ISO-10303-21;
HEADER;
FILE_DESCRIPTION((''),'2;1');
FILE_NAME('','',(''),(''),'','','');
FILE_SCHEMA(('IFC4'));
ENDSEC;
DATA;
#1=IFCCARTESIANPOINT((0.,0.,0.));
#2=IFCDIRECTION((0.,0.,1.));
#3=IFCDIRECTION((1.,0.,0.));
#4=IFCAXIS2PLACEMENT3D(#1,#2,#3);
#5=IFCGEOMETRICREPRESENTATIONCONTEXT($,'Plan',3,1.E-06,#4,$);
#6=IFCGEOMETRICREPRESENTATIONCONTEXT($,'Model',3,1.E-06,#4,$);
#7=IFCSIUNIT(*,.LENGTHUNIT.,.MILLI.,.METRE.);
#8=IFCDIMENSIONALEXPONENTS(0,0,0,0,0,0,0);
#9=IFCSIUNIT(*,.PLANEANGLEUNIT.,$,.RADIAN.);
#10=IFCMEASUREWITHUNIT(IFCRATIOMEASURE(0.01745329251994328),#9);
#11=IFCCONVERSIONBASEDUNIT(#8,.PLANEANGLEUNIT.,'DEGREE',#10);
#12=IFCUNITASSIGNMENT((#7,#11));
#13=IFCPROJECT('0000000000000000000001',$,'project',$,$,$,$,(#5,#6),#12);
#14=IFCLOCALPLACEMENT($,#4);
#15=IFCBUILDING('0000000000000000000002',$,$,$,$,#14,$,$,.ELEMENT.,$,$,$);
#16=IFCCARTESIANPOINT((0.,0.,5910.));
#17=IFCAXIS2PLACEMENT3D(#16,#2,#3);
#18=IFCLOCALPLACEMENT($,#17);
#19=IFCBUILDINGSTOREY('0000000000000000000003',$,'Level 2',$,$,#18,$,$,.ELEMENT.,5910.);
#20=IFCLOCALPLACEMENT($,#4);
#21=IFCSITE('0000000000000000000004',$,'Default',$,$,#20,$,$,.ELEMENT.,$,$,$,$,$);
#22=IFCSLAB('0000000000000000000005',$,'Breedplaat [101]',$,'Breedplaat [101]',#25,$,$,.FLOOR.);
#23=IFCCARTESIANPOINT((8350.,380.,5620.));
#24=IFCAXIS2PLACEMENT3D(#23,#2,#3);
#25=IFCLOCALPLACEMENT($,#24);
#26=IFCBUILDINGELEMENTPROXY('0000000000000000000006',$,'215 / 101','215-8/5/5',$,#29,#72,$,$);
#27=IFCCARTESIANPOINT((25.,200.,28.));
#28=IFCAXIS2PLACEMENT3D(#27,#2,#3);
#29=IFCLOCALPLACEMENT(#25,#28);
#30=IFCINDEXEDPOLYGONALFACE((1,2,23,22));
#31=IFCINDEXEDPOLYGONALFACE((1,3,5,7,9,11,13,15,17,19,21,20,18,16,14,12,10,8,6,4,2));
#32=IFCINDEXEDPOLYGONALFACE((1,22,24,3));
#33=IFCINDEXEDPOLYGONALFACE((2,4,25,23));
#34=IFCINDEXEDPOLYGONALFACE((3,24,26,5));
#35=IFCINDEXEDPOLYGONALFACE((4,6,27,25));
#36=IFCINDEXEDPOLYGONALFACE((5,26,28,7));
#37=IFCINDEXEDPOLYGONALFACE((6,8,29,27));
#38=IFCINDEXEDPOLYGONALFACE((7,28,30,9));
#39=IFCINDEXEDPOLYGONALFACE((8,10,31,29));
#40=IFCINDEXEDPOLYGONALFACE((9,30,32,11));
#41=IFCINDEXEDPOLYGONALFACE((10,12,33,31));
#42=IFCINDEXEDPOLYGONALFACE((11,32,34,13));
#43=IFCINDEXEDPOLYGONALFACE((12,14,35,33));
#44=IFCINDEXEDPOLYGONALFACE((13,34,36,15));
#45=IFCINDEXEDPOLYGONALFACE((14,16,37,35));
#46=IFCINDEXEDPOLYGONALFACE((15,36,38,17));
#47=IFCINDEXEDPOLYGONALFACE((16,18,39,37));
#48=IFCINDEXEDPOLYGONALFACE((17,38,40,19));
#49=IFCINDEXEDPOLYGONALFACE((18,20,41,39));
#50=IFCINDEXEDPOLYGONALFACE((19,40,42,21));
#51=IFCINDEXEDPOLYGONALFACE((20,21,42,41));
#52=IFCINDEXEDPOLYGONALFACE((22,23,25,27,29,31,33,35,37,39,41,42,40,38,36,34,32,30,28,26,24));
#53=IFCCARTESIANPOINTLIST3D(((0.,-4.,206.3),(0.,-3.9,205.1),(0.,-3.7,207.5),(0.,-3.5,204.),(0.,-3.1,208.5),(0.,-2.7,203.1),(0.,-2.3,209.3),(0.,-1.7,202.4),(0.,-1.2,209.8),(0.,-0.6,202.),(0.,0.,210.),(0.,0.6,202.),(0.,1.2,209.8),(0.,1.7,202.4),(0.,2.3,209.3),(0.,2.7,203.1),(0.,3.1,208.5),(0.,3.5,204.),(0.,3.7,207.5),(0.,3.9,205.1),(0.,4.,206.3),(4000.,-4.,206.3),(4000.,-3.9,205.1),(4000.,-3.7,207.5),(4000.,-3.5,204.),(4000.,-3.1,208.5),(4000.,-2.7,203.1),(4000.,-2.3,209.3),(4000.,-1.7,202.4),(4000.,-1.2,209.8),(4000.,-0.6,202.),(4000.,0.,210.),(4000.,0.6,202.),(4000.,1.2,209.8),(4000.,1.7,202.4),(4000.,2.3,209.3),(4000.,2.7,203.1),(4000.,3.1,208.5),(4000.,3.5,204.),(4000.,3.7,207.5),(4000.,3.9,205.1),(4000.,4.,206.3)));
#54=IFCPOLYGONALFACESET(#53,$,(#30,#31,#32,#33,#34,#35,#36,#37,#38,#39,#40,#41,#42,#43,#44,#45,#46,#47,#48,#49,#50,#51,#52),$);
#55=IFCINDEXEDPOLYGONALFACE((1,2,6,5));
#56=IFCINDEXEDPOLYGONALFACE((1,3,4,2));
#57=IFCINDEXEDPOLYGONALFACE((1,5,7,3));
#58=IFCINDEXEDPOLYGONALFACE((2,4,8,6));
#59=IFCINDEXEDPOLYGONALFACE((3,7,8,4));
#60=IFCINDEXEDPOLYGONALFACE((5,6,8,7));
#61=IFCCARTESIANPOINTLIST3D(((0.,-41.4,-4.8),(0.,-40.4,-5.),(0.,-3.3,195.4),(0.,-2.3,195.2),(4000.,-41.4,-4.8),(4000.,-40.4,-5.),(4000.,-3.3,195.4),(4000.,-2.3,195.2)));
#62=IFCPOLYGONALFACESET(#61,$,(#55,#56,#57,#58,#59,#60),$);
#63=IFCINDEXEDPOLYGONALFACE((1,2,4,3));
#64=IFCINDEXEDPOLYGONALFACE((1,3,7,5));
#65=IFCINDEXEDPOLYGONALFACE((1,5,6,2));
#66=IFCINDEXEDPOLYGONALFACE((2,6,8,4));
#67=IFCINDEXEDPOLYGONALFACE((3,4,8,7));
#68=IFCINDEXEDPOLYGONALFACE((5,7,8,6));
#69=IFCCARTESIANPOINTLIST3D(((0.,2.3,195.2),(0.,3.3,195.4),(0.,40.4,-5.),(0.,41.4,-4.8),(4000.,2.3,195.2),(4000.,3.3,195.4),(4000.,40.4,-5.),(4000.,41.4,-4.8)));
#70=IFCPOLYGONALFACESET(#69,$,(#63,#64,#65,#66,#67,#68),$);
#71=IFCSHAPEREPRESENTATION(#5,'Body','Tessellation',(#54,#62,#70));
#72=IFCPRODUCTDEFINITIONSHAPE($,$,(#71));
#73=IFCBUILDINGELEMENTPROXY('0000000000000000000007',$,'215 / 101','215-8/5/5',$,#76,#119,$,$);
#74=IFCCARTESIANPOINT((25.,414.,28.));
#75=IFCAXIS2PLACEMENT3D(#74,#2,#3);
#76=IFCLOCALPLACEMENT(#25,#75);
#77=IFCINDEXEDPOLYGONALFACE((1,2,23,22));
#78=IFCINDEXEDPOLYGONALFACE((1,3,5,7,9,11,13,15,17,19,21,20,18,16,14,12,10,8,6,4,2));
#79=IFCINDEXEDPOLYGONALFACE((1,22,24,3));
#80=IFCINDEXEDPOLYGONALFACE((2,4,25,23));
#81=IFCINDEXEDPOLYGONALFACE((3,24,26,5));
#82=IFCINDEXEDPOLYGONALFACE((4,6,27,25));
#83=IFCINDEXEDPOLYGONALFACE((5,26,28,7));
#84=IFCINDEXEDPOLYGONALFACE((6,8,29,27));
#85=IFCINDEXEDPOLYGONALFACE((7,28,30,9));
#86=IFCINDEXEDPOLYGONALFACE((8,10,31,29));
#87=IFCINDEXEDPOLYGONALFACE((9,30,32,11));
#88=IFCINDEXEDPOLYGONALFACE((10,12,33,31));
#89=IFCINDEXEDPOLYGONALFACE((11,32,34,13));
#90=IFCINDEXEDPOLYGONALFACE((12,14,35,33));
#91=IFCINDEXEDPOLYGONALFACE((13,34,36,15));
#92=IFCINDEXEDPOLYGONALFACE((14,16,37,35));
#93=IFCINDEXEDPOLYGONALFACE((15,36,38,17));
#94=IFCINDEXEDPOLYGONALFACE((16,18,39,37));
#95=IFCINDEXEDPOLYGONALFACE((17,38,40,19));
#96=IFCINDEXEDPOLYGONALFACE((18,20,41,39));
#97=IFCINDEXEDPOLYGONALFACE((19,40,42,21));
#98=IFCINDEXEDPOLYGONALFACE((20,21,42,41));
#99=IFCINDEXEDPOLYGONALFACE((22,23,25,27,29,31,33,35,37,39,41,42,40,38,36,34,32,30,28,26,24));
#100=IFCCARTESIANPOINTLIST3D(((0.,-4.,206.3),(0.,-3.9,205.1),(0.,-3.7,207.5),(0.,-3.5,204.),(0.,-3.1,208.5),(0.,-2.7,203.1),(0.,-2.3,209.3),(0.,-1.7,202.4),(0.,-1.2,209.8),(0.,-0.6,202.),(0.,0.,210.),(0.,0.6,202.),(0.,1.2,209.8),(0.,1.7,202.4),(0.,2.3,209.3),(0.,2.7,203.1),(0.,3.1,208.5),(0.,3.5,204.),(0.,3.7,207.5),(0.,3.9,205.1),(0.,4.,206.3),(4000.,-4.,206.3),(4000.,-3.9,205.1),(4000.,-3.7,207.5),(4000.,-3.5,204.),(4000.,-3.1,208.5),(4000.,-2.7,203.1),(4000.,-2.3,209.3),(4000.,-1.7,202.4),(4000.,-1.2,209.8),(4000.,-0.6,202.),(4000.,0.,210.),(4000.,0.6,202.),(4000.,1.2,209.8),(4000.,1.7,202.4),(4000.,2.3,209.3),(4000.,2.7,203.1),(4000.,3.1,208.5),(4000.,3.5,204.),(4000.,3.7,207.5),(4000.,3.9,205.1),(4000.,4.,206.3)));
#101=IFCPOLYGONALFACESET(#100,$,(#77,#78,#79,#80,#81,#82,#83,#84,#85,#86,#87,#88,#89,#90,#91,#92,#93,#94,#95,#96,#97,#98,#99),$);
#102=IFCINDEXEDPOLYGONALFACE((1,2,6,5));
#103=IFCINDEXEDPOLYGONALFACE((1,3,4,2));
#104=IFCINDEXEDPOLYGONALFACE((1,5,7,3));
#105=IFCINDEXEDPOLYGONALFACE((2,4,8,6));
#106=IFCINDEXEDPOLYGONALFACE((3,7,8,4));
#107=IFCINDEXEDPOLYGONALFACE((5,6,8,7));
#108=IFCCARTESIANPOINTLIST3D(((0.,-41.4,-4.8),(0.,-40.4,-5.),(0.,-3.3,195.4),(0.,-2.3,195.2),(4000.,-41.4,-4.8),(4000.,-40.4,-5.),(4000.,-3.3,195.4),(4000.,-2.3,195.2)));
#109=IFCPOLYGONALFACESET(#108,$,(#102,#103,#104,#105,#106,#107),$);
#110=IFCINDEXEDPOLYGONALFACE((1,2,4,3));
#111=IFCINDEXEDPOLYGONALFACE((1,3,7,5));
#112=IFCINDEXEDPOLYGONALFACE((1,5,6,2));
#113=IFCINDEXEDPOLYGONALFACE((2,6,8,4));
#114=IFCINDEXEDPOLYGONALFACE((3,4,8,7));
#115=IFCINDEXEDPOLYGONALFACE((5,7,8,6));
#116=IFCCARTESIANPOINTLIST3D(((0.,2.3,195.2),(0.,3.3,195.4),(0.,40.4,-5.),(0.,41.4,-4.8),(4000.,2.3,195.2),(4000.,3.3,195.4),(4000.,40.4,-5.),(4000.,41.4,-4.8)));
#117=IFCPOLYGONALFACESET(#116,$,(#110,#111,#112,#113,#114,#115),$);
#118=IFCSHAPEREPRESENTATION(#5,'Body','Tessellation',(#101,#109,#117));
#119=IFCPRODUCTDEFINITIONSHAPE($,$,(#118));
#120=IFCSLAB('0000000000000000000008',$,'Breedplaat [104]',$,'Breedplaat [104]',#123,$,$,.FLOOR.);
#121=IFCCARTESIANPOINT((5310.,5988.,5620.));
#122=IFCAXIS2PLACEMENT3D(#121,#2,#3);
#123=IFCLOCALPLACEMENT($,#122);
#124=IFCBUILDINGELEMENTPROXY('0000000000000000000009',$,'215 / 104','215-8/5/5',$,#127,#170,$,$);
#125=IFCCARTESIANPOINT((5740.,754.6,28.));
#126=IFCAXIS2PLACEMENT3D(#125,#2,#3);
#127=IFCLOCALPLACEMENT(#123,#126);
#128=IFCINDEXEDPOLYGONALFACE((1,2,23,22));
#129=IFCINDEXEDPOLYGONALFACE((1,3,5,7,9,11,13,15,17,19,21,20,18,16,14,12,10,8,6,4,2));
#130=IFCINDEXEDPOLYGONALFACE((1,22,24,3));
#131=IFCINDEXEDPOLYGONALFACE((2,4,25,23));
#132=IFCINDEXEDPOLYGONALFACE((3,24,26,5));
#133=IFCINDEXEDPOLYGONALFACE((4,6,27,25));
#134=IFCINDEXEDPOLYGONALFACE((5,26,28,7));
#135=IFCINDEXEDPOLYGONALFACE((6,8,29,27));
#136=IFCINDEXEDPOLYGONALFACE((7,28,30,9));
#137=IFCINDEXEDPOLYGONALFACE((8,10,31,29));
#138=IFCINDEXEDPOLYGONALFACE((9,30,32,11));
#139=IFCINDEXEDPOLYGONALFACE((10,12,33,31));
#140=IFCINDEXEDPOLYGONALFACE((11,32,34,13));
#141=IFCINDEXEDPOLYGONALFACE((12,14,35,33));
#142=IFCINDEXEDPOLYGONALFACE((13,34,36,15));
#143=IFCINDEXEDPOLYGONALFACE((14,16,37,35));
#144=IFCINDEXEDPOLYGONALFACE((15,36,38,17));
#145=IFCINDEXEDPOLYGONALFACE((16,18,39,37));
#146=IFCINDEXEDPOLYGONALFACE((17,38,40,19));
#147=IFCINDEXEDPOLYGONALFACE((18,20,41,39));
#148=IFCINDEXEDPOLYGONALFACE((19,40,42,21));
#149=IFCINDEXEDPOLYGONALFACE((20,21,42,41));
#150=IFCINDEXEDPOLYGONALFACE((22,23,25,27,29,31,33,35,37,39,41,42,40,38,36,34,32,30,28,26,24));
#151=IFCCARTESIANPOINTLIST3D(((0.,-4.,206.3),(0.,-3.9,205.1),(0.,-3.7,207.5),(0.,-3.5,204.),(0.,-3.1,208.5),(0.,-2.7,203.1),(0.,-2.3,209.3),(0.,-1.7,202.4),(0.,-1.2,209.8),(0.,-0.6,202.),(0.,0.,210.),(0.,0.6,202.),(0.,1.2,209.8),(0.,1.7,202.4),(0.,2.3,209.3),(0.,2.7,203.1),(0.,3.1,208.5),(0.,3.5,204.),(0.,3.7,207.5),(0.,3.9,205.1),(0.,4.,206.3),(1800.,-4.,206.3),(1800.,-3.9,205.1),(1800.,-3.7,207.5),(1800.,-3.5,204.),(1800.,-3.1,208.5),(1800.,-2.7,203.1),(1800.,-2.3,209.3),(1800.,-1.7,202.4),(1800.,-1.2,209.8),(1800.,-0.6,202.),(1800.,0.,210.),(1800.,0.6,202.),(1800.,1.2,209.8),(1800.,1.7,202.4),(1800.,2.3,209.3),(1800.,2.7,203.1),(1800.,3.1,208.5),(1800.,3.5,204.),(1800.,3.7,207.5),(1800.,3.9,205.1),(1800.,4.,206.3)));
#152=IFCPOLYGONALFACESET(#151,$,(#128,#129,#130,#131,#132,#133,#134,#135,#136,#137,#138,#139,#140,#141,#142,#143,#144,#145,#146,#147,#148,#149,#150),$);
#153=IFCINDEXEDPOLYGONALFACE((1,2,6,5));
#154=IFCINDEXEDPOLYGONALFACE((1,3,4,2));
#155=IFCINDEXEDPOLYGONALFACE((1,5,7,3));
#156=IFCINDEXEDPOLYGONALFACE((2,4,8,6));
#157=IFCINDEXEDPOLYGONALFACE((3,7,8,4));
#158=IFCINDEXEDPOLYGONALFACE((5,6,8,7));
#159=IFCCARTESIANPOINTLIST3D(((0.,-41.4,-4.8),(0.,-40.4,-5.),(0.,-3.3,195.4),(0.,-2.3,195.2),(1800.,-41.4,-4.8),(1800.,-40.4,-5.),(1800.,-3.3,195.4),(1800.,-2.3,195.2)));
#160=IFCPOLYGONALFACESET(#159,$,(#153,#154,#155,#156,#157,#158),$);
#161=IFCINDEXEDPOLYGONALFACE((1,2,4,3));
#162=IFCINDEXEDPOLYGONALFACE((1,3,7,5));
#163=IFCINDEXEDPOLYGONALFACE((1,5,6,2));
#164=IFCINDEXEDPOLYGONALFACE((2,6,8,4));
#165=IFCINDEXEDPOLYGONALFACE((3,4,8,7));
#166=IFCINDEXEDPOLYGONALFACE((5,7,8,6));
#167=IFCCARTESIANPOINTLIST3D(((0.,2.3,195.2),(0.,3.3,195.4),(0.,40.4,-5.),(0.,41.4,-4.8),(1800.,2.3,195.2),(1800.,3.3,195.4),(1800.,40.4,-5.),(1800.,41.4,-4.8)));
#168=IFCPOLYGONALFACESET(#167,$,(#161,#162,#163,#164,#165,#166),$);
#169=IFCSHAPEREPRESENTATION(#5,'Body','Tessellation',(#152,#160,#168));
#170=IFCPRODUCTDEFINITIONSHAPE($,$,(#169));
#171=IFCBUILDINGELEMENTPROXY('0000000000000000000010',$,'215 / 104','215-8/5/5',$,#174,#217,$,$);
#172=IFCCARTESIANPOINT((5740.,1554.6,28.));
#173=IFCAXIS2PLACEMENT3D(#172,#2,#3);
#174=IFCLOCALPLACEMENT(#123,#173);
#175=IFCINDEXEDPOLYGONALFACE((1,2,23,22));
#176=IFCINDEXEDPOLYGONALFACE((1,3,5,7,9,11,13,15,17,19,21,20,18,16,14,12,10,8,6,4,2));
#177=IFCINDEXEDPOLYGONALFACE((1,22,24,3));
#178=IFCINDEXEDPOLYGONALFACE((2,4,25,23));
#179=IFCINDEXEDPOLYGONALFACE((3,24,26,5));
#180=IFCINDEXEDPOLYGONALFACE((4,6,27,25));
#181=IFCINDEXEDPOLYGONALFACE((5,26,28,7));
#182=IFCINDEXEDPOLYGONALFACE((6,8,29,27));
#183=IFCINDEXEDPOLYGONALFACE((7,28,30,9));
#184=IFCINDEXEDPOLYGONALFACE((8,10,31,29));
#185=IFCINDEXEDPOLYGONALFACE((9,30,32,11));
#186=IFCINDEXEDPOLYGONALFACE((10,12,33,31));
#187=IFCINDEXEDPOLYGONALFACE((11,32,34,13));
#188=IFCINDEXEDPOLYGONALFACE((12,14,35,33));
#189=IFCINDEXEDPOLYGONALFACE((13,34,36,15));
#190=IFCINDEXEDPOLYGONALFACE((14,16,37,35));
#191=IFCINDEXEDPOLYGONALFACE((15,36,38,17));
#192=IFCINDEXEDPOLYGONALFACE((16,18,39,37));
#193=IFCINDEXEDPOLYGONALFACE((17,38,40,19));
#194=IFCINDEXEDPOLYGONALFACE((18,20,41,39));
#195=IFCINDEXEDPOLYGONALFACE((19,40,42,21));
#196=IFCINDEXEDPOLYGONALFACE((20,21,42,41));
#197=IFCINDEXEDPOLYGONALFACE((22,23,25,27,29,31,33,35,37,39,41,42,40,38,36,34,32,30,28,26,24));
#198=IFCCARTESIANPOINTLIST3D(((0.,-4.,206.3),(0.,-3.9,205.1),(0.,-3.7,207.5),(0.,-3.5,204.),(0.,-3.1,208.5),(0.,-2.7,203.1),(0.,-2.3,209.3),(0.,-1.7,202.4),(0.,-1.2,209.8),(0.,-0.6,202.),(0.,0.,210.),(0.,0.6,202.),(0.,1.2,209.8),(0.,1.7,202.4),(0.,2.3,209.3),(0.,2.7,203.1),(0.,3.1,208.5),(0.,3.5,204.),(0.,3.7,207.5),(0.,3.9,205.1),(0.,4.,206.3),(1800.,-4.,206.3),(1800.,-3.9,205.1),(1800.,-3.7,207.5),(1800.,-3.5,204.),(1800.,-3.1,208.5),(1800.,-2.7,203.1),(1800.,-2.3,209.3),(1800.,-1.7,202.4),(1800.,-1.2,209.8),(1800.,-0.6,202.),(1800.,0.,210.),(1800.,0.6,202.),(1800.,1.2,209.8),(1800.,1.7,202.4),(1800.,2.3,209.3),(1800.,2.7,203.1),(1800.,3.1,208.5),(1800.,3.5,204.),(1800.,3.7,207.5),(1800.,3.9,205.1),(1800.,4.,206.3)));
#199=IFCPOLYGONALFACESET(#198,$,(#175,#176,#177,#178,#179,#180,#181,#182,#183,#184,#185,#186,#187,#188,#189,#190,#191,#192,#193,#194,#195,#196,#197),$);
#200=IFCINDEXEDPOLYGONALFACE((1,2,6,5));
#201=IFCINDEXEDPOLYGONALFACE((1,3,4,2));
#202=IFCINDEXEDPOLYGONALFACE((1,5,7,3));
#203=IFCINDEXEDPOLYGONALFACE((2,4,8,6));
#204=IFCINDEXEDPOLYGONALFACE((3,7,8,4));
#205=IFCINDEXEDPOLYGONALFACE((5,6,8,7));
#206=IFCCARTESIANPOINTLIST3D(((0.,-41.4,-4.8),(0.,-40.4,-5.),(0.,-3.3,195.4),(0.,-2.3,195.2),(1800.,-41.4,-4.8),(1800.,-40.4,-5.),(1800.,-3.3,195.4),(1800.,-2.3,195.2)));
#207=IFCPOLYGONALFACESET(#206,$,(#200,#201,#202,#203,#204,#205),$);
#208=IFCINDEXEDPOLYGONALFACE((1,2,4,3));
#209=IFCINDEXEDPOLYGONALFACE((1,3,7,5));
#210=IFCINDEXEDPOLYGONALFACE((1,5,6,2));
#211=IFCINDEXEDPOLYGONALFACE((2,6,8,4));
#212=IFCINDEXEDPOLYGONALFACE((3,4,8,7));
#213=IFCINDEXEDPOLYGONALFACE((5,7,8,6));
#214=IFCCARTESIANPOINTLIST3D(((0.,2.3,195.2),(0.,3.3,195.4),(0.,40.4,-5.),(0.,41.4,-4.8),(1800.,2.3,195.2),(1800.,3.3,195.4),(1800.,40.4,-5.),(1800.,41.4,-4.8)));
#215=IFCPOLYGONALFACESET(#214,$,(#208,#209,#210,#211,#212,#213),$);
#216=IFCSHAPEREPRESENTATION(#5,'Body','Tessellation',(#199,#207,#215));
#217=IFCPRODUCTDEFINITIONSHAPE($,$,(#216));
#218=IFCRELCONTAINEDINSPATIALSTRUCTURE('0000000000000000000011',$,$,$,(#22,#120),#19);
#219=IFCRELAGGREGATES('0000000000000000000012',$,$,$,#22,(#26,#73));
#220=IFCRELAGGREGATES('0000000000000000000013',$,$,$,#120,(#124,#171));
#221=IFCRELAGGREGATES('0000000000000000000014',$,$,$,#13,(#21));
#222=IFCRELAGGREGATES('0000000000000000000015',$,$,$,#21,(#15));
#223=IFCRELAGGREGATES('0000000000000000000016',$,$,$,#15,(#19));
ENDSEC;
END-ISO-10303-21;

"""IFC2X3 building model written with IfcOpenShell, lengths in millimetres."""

from ifc_helpers import new_model, entity, si_unit, converted_unit, frame, origin_with_axes, origin_2d_with_axis, place, context, project, spatial, rectangle, circle, extrude, element, aggregate, save


model = new_model("IFC2X3")

# Units and contexts
plan_context = context("Plan", 3, precision=1e-06, world=origin_with_axes())
model_context = context("Model", 3, precision=1e-06, world=origin_with_axes())
ifc_project = project(units=[si_unit("LENGTHUNIT", "METRE", prefix="MILLI"), converted_unit("PLANEANGLEUNIT", "DEGREE", entity("IfcRatioMeasure", 0.01745329251994328), si_unit("PLANEANGLEUNIT", "RADIAN"), dimensions=[0, 0, 0, 0, 0, 0, 0])], contexts=[plan_context, model_context])

# Site, building, storey
site_placement = place(None, origin_with_axes())
site = spatial("IfcSite", under=ifc_project, at=site_placement, Name="Default", CompositionType="ELEMENT")
building_placement = place(None, origin_with_axes())
building = spatial("IfcBuilding", under=site, at=building_placement, CompositionType="ELEMENT")
storey_placement = place(None, frame((0.0, 0.0, 5910.0), z_axis=(0.0, 0.0, 1.0), x_axis=(1.0, 0.0, 0.0)))
storey = spatial("IfcBuildingStorey", under=building, at=storey_placement, Name="Level 2", CompositionType="ELEMENT", Elevation=5910.0)

# Slab, building element proxies
slab_1_placement = place(None, frame((8350.0, 380.0, 5620.0), z_axis=(0.0, 0.0, 1.0), x_axis=(1.0, 0.0, 0.0)))
slab_1 = element("IfcSlab", 1, at=slab_1_placement, inside=storey, Name="Breedplaat [101]", ObjectType="Breedplaat [101]", PredefinedType="FLOOR")
proxy_1_placement = place(slab_1_placement, frame((25.0, 200.0, 28.0), z_axis=(0.0, 0.0, 1.0), x_axis=(1.0, 0.0, 0.0)))
proxy_1 = element("IfcBuildingElementProxy", 2, at=proxy_1_placement, Name="215 / 101", Description="215-8/5/5", context=plan_context, shape_type="SweptSolid", body=[
    extrude(circle(Radius=4.0, at=origin_2d_with_axis()), frame((0.0, 0.0, 206.0), z_axis=(1.0, 0.0, 0.0), x_axis=(0.0, 0.0, 1.0)), (0.0, 0.0, 1.0), 4000.0),
    extrude(rectangle(XDim=203.8, YDim=1.0, at=origin_2d_with_axis()), frame((0.0, -21.9, 95.2), z_axis=(1.0, 0.0, 0.0), x_axis=(0.0, 0.187112, 0.982339)), (0.0, 0.0, 1.0), 4000.0),
    extrude(rectangle(XDim=203.8, YDim=1.0, at=origin_2d_with_axis()), frame((0.0, 21.9, 95.2), z_axis=(1.0, 0.0, 0.0), x_axis=(0.0, -0.187112, 0.982339)), (0.0, 0.0, 1.0), 4000.0),
])
proxy_2_placement = place(slab_1_placement, frame((25.0, 414.0, 28.0), z_axis=(0.0, 0.0, 1.0), x_axis=(1.0, 0.0, 0.0)))
proxy_2 = element("IfcBuildingElementProxy", 3, at=proxy_2_placement, Name="215 / 101", Description="215-8/5/5", context=plan_context, shape_type="SweptSolid", body=[
    extrude(circle(Radius=4.0, at=origin_2d_with_axis()), frame((0.0, 0.0, 206.0), z_axis=(1.0, 0.0, 0.0), x_axis=(0.0, 0.0, 1.0)), (0.0, 0.0, 1.0), 4000.0),
    extrude(rectangle(XDim=203.8, YDim=1.0, at=origin_2d_with_axis()), frame((0.0, -21.9, 95.2), z_axis=(1.0, 0.0, 0.0), x_axis=(0.0, 0.187112, 0.982339)), (0.0, 0.0, 1.0), 4000.0),
    extrude(rectangle(XDim=203.8, YDim=1.0, at=origin_2d_with_axis()), frame((0.0, 21.9, 95.2), z_axis=(1.0, 0.0, 0.0), x_axis=(0.0, -0.187112, 0.982339)), (0.0, 0.0, 1.0), 4000.0),
])
aggregate(slab_1, [proxy_1, proxy_2])

# Slab, building element proxies
slab_2_placement = place(None, frame((5310.0, 5988.0, 5620.0), z_axis=(0.0, 0.0, 1.0), x_axis=(1.0, 0.0, 0.0)))
slab_2 = element("IfcSlab", 4, at=slab_2_placement, inside=storey, Name="Breedplaat [104]", ObjectType="Breedplaat [104]", PredefinedType="FLOOR")
proxy_3_placement = place(slab_2_placement, frame((5740.0, 754.6, 28.0), z_axis=(0.0, 0.0, 1.0), x_axis=(1.0, 0.0, 0.0)))
proxy_3 = element("IfcBuildingElementProxy", 5, at=proxy_3_placement, Name="215 / 104", Description="215-8/5/5", context=plan_context, shape_type="SweptSolid", body=[
    extrude(circle(Radius=4.0, at=origin_2d_with_axis()), frame((0.0, 0.0, 206.0), z_axis=(1.0, 0.0, 0.0), x_axis=(0.0, 0.0, 1.0)), (0.0, 0.0, 1.0), 1800.0),
    extrude(rectangle(XDim=203.8, YDim=1.0, at=origin_2d_with_axis()), frame((0.0, -21.9, 95.2), z_axis=(1.0, 0.0, 0.0), x_axis=(0.0, 0.187112, 0.982339)), (0.0, 0.0, 1.0), 1800.0),
    extrude(rectangle(XDim=203.8, YDim=1.0, at=origin_2d_with_axis()), frame((0.0, 21.9, 95.2), z_axis=(1.0, 0.0, 0.0), x_axis=(0.0, -0.187112, 0.982339)), (0.0, 0.0, 1.0), 1800.0),
])
proxy_4_placement = place(slab_2_placement, frame((5740.0, 1554.6, 28.0), z_axis=(0.0, 0.0, 1.0), x_axis=(1.0, 0.0, 0.0)))
proxy_4 = element("IfcBuildingElementProxy", 6, at=proxy_4_placement, Name="215 / 104", Description="215-8/5/5", context=plan_context, shape_type="SweptSolid", body=[
    extrude(circle(Radius=4.0, at=origin_2d_with_axis()), frame((0.0, 0.0, 206.0), z_axis=(1.0, 0.0, 0.0), x_axis=(0.0, 0.0, 1.0)), (0.0, 0.0, 1.0), 1800.0),
    extrude(rectangle(XDim=203.8, YDim=1.0, at=origin_2d_with_axis()), frame((0.0, -21.9, 95.2), z_axis=(1.0, 0.0, 0.0), x_axis=(0.0, 0.187112, 0.982339)), (0.0, 0.0, 1.0), 1800.0),
    extrude(rectangle(XDim=203.8, YDim=1.0, at=origin_2d_with_axis()), frame((0.0, 21.9, 95.2), z_axis=(1.0, 0.0, 0.0), x_axis=(0.0, -0.187112, 0.982339)), (0.0, 0.0, 1.0), 1800.0),
])
aggregate(slab_2, [proxy_3, proxy_4])

save(model, "model.ifc")
